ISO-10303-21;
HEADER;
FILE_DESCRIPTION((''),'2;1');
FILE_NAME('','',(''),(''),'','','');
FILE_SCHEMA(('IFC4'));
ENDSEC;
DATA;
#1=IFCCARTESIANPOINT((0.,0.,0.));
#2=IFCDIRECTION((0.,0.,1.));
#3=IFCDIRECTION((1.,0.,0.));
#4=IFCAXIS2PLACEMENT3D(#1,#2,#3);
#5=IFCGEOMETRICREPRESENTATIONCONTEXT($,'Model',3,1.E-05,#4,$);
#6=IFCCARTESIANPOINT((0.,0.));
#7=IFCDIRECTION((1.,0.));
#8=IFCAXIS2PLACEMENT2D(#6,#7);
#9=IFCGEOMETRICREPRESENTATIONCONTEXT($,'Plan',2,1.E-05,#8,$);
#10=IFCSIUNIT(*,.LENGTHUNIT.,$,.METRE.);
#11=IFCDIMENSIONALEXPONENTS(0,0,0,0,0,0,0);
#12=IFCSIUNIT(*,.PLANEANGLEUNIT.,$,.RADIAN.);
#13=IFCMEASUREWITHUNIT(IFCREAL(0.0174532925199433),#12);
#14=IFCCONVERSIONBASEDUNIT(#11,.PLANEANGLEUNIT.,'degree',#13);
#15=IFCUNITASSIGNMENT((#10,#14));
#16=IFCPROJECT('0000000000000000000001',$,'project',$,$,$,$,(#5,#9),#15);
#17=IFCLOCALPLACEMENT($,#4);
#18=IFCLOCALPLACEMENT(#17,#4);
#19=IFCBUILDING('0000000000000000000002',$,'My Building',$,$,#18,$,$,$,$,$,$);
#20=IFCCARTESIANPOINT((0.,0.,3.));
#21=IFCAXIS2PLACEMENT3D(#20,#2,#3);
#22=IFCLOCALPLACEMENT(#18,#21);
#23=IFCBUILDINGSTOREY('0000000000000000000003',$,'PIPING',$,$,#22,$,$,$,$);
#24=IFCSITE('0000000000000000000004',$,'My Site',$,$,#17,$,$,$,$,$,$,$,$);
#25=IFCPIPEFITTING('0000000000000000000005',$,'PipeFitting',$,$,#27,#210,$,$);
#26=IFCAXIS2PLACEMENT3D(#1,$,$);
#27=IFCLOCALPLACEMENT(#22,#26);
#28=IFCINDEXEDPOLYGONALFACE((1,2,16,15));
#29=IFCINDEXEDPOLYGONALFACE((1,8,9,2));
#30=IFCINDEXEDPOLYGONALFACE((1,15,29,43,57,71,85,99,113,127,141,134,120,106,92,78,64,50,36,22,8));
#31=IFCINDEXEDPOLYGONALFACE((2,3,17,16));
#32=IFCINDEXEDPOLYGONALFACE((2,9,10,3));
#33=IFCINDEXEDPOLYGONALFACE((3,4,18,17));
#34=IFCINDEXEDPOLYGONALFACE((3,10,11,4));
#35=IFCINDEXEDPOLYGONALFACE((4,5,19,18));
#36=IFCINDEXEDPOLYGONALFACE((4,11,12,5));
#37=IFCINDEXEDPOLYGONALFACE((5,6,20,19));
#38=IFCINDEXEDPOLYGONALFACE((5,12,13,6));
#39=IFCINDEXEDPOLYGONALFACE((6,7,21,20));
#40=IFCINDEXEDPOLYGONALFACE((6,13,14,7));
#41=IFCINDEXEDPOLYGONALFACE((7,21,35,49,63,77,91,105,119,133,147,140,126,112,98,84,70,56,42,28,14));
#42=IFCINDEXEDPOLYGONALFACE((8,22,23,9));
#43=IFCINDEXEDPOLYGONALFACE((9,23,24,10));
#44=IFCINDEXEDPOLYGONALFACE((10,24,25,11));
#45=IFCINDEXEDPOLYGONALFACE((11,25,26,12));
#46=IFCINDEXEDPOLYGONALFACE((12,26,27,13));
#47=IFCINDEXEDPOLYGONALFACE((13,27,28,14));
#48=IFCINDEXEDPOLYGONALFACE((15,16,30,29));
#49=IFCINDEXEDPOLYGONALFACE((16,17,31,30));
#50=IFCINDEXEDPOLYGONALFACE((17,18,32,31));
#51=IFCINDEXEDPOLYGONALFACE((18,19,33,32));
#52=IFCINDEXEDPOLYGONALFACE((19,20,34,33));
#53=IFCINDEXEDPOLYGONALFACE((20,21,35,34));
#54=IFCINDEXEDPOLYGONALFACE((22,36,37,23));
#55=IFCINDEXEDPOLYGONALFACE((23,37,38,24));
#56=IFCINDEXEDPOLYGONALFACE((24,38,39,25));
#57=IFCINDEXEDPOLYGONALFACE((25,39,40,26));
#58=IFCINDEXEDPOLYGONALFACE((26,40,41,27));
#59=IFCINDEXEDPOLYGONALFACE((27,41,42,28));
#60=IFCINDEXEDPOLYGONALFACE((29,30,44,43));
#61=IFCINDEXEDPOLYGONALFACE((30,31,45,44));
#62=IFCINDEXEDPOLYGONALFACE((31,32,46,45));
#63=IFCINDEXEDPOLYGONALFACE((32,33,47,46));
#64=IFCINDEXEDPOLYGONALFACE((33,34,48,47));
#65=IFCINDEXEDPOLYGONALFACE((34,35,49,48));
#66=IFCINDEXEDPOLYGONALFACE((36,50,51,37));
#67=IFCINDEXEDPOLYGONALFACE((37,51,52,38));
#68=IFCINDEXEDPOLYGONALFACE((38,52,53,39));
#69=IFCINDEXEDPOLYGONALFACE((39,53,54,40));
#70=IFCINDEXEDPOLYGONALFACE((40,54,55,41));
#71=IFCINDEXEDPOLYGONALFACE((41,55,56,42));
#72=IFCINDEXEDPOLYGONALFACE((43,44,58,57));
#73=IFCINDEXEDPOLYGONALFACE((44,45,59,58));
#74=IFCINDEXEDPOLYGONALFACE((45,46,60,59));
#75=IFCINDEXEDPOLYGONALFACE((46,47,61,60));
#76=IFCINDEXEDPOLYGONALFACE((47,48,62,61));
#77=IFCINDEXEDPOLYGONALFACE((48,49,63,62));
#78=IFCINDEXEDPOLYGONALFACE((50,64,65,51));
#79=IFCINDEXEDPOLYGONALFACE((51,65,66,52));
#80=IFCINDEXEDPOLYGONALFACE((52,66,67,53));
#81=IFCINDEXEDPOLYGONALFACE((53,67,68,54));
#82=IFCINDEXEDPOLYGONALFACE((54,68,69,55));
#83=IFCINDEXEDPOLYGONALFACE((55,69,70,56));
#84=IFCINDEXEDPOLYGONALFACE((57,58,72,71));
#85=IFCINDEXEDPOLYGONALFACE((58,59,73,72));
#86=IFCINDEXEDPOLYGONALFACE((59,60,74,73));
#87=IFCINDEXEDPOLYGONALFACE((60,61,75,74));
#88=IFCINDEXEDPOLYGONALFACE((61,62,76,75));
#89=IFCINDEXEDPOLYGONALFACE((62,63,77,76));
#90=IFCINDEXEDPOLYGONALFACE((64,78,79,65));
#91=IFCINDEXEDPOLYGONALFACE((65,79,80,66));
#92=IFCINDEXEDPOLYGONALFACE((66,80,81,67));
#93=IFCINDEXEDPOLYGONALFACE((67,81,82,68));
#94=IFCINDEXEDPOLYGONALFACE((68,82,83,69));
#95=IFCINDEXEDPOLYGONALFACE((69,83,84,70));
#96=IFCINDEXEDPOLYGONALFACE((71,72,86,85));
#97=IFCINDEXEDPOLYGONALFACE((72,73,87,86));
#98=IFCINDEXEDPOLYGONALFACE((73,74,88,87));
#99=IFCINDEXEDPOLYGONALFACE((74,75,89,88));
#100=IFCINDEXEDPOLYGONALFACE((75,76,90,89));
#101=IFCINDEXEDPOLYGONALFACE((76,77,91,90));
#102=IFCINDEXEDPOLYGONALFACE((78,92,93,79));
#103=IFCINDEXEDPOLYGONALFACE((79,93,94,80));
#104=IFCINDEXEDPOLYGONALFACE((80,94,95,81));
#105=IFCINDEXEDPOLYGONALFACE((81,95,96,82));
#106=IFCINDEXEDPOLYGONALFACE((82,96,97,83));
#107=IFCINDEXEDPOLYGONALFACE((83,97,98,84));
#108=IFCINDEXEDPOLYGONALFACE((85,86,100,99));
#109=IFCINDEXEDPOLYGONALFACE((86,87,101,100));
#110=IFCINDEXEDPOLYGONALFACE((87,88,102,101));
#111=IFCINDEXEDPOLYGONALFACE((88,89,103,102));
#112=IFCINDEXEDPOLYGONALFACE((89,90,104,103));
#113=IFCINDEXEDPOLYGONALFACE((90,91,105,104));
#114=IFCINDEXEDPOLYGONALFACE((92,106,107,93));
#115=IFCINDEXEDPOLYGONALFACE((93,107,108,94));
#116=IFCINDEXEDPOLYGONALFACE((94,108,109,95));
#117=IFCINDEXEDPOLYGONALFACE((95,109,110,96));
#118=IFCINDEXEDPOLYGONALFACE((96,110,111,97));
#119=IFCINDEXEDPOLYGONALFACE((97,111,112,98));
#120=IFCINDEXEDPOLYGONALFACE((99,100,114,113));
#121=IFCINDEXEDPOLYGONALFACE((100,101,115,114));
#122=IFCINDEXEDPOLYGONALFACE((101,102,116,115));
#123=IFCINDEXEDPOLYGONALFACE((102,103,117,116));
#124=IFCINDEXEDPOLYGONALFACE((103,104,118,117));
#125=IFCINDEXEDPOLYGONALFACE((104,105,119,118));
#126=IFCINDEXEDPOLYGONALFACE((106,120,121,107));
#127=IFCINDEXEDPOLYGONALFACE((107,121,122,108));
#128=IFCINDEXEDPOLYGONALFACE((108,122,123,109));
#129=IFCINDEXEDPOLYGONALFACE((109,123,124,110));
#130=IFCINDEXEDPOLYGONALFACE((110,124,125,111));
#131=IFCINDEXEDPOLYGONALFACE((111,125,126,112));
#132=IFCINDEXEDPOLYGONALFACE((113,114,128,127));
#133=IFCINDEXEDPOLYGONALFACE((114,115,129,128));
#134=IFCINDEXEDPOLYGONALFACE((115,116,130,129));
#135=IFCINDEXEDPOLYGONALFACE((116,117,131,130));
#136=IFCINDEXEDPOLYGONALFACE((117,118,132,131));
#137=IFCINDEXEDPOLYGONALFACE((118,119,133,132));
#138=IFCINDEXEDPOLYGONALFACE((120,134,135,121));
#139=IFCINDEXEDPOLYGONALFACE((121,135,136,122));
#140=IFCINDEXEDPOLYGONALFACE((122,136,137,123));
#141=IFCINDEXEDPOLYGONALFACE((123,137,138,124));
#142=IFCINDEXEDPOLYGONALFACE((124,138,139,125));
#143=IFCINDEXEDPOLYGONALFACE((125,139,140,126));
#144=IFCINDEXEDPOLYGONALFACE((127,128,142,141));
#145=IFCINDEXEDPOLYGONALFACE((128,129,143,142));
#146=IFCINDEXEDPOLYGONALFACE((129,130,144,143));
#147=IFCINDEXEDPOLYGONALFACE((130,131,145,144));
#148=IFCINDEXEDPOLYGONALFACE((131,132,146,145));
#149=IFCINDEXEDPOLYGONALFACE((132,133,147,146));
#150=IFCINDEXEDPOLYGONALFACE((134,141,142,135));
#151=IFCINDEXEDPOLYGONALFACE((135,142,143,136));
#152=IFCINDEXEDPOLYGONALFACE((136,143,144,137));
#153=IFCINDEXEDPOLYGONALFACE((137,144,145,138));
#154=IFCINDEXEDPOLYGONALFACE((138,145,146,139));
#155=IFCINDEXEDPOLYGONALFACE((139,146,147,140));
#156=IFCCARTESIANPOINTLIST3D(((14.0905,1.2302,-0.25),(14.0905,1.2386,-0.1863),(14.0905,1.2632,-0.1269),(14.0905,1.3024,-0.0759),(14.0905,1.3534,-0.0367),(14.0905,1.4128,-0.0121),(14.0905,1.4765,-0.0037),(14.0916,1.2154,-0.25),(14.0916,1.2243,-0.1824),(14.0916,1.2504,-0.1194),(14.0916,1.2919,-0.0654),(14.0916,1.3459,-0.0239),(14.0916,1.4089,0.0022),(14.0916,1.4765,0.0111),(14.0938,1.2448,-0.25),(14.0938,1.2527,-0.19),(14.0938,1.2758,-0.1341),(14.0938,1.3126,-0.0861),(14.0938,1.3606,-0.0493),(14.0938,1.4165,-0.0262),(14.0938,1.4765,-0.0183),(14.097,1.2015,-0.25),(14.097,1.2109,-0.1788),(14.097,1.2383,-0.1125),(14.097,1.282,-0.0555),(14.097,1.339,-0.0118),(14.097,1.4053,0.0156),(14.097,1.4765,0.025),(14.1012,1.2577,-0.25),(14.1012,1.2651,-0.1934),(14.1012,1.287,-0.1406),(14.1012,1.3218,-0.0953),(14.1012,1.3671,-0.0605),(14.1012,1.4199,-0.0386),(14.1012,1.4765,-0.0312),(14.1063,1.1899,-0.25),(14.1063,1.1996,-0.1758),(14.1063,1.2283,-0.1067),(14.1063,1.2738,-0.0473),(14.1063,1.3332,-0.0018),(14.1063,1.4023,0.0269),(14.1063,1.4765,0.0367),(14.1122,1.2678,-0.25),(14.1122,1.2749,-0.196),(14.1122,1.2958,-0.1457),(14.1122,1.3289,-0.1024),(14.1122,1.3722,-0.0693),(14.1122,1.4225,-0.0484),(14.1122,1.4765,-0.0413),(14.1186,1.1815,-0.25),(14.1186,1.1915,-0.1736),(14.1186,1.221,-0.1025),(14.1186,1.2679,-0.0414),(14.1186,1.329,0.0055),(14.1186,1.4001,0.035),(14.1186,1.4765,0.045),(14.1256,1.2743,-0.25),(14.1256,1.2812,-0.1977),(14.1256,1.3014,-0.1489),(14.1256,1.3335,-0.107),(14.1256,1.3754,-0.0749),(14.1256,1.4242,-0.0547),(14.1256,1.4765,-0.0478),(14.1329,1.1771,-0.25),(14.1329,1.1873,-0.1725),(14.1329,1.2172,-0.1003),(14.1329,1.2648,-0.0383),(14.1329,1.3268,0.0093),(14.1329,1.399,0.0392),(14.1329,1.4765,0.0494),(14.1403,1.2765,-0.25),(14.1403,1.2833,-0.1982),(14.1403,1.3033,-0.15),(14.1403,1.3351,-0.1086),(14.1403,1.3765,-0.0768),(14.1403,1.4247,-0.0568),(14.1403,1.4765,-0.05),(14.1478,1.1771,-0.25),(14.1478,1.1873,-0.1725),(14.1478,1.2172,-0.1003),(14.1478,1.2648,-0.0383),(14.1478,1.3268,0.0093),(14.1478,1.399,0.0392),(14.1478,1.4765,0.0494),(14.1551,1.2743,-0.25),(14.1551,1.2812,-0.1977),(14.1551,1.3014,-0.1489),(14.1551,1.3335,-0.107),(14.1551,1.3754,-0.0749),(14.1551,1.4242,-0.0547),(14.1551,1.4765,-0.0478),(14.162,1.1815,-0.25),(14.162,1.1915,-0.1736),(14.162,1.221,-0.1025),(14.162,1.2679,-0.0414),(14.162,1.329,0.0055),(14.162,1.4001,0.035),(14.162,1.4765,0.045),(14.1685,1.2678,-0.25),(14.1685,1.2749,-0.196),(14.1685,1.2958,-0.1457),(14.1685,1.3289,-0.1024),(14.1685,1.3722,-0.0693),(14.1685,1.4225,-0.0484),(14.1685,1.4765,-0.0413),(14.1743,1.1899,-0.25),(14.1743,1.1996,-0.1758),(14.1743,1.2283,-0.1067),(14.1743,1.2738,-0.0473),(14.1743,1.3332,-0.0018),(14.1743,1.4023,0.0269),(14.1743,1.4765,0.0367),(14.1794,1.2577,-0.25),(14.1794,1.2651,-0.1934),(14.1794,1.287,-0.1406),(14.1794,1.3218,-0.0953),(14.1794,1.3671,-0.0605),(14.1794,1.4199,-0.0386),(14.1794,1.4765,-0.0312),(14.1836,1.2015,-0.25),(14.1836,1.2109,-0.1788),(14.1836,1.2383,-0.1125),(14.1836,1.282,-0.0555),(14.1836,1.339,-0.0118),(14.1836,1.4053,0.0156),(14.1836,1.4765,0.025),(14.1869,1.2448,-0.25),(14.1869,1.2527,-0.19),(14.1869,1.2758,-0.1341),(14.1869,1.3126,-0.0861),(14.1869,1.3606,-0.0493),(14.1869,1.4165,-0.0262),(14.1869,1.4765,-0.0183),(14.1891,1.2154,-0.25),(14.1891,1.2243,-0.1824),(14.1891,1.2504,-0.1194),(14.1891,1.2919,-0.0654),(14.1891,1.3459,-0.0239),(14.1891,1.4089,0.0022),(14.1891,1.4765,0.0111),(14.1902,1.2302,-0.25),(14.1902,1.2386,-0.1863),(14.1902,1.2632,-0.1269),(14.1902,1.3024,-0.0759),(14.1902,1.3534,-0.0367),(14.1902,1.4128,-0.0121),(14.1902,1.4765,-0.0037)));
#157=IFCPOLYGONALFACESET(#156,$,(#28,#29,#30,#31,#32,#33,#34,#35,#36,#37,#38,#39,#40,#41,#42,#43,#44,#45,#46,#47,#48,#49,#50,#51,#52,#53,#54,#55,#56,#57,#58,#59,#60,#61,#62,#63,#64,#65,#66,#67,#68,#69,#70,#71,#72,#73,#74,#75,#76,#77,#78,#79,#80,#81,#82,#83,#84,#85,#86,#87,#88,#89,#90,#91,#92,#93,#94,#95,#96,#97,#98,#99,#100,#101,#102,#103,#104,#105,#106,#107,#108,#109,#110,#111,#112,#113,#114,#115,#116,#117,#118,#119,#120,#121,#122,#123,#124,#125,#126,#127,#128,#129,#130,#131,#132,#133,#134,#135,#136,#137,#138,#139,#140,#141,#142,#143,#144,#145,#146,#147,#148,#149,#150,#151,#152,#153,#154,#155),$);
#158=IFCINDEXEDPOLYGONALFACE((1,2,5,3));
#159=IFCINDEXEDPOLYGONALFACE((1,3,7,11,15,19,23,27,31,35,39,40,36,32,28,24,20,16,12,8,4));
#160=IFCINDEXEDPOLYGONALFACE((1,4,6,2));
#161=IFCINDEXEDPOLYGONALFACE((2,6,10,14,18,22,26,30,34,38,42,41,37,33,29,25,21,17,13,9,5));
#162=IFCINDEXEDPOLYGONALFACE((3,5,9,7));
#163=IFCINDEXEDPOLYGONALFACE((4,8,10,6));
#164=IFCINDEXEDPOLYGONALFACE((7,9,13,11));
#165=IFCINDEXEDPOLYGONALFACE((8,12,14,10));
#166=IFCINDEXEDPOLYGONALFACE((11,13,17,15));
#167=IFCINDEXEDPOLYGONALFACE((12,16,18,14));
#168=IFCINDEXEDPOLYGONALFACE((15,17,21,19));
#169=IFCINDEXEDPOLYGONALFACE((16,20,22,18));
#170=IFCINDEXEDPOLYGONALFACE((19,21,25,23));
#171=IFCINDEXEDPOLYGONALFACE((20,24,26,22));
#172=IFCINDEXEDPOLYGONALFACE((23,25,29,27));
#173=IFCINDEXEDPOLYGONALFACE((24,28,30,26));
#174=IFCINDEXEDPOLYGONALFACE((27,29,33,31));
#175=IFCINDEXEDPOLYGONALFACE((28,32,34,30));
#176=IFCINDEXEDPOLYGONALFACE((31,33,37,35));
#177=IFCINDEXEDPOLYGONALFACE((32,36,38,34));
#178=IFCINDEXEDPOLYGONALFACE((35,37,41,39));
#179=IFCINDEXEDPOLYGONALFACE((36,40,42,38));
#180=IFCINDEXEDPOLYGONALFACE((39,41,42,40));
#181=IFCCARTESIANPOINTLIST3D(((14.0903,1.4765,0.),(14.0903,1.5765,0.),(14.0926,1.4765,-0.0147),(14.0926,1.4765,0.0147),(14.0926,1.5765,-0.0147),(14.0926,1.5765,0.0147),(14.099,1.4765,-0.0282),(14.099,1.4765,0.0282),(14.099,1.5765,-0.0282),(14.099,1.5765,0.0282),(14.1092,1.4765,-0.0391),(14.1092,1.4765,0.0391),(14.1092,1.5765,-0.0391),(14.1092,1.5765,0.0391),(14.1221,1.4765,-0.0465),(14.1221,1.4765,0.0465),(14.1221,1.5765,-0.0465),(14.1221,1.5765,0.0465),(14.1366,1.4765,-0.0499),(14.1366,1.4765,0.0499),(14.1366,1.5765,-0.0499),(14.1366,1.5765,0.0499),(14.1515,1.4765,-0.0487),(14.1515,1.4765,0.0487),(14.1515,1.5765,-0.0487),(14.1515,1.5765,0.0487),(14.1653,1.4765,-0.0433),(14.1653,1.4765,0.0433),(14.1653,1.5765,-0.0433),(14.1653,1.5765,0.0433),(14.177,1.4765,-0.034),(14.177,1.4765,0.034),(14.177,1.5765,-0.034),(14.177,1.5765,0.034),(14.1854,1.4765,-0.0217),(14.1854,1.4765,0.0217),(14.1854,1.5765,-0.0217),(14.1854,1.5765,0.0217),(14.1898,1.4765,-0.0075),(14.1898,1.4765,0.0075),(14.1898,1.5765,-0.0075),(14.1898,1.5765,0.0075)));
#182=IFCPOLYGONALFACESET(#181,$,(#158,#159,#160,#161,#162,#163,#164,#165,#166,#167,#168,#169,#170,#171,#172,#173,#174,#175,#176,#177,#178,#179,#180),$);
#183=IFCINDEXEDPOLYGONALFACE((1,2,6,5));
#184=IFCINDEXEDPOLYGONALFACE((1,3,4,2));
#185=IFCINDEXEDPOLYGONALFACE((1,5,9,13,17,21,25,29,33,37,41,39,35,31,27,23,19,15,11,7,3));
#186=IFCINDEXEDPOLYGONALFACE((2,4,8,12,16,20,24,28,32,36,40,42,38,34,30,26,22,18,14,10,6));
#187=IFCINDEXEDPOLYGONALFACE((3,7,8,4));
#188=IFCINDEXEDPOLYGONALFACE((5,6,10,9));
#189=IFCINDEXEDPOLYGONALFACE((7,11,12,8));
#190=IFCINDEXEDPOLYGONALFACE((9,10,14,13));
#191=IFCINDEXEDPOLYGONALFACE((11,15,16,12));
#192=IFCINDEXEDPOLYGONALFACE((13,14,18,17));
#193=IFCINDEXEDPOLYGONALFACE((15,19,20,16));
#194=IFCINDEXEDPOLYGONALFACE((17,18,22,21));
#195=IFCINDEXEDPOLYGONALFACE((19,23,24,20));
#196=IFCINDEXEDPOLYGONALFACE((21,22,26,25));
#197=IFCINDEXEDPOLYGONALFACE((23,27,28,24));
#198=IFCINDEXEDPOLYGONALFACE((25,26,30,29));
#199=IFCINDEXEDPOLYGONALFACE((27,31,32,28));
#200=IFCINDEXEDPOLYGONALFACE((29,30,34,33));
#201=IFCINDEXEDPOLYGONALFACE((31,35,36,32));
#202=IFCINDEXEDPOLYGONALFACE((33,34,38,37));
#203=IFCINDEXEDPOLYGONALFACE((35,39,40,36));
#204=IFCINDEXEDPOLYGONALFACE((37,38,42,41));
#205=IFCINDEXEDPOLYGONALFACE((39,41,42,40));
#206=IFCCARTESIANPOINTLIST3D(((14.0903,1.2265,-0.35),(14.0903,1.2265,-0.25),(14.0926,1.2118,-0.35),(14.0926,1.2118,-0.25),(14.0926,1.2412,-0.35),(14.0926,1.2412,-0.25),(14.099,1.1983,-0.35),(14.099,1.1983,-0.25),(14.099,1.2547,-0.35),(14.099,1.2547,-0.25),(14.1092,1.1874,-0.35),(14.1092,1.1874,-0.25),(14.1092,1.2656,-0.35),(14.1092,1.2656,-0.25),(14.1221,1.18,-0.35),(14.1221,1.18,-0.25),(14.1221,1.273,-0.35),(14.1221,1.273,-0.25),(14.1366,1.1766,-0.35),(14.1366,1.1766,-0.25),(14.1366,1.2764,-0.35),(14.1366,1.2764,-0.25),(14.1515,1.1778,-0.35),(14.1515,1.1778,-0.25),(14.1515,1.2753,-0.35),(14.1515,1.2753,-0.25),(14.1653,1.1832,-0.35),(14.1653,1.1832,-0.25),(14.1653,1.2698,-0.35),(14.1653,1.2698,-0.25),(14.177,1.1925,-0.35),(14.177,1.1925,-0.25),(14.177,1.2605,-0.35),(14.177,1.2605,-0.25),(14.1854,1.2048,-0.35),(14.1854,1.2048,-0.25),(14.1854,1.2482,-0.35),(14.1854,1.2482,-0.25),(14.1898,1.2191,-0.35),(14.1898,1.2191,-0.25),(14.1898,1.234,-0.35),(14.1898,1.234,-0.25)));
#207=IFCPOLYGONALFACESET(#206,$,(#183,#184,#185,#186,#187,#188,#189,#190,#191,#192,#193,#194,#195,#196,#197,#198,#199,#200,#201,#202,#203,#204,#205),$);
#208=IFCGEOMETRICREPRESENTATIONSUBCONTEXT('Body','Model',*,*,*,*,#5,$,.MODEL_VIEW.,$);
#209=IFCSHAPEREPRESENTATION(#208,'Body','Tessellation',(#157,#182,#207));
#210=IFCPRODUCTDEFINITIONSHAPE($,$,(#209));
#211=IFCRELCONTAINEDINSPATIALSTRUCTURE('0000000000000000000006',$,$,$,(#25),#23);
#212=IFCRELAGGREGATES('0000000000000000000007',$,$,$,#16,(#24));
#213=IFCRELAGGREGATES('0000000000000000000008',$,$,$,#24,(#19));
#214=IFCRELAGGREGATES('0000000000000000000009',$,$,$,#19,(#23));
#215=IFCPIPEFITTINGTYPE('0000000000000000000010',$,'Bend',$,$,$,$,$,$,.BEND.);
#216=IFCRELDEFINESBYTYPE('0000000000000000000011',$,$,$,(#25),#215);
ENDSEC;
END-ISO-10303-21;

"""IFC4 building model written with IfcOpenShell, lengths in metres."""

from ifc_helpers import new_model, entity, si_unit, converted_unit, frame, origin_with_axes, origin_2d_with_axis, place, context, subcontext, project, spatial, circle, extrude, source, transform, mapped, type_object, type_shapes, element, save


model = new_model("IFC4")

# Units and contexts
model_context = context("Model", 3, precision=1e-05, world=origin_with_axes())
plan_context = context("Plan", 2, precision=1e-05, world=origin_2d_with_axis())
body_context = subcontext(model_context, "Body", "Model", "MODEL_VIEW")
ifc_project = project(units=[si_unit("LENGTHUNIT", "METRE"), converted_unit("PLANEANGLEUNIT", "degree", entity("IfcReal", 0.0174532925199433), si_unit("PLANEANGLEUNIT", "RADIAN"), dimensions=[0, 0, 0, 0, 0, 0, 0])], contexts=[model_context, plan_context])

# Site, building, storey
site_placement = place(None, origin_with_axes())
site = spatial("IfcSite", under=ifc_project, at=site_placement, Name="My Site")
building_placement = place(site_placement, origin_with_axes())
building = spatial("IfcBuilding", under=site, at=building_placement, Name="My Building")
storey_placement = place(building_placement, frame((0.0, 0.0, 3.0), z_axis=(0.0, 0.0, 1.0), x_axis=(1.0, 0.0, 0.0)))
storey = spatial("IfcBuildingStorey", under=building, at=storey_placement, Name="PIPING")

# Pipe fitting
pipe_fitting_type = type_object("IfcPipeFittingType", Name="Bend", PredefinedType="BEND")
shared_shape = source(origin_with_axes(), body_context, "Body", "SolidModel", [
    entity("IfcSweptDiskSolid", entity("IfcIndexedPolyCurve", entity("IfcCartesianPointList3D", [[0.0, 0.0, -0.1], [0.0, -0.0732, -0.2768], [0.0, -0.25, -0.35]]), [entity("IfcArcIndex", [1, 2, 3])]), 0.05),
    extrude(circle(Radius=0.05), origin_with_axes(), (0.0, 0.0, -1.0), 0.1),
    extrude(circle(Radius=0.05), frame((0.0, -0.25, -0.35), z_axis=(0.0, -1.0, 0.0), x_axis=(1.0, 0.0, 0.0)), (0.0, 0.0, 1.0), 0.1),
])
type_shapes(pipe_fitting_type, [shared_shape])
for number, where, z_axis, x_axis, name in (
    (1, (14.1403, 1.5765, 0.0), (0.0, 1.0, 0.0), (-1.0, 0.0, 0.0), "PipeFitting"),
):
    element("IfcPipeFitting", number, at=place(storey_placement, frame(where, z_axis=z_axis, x_axis=x_axis)), inside=storey, type_object=pipe_fitting_type, Name=name, context=body_context, shape_type="MappedRepresentation", body=[
        mapped(shared_shape, transform((0.0, 0.0, 0.0), x_axis=(1.0, 0.0, 0.0), y_axis=(0.0, 1.0, 0.0), z_axis=(0.0, 0.0, 1.0), scale=1.0)),
    ])

save(model, "model.ifc")
